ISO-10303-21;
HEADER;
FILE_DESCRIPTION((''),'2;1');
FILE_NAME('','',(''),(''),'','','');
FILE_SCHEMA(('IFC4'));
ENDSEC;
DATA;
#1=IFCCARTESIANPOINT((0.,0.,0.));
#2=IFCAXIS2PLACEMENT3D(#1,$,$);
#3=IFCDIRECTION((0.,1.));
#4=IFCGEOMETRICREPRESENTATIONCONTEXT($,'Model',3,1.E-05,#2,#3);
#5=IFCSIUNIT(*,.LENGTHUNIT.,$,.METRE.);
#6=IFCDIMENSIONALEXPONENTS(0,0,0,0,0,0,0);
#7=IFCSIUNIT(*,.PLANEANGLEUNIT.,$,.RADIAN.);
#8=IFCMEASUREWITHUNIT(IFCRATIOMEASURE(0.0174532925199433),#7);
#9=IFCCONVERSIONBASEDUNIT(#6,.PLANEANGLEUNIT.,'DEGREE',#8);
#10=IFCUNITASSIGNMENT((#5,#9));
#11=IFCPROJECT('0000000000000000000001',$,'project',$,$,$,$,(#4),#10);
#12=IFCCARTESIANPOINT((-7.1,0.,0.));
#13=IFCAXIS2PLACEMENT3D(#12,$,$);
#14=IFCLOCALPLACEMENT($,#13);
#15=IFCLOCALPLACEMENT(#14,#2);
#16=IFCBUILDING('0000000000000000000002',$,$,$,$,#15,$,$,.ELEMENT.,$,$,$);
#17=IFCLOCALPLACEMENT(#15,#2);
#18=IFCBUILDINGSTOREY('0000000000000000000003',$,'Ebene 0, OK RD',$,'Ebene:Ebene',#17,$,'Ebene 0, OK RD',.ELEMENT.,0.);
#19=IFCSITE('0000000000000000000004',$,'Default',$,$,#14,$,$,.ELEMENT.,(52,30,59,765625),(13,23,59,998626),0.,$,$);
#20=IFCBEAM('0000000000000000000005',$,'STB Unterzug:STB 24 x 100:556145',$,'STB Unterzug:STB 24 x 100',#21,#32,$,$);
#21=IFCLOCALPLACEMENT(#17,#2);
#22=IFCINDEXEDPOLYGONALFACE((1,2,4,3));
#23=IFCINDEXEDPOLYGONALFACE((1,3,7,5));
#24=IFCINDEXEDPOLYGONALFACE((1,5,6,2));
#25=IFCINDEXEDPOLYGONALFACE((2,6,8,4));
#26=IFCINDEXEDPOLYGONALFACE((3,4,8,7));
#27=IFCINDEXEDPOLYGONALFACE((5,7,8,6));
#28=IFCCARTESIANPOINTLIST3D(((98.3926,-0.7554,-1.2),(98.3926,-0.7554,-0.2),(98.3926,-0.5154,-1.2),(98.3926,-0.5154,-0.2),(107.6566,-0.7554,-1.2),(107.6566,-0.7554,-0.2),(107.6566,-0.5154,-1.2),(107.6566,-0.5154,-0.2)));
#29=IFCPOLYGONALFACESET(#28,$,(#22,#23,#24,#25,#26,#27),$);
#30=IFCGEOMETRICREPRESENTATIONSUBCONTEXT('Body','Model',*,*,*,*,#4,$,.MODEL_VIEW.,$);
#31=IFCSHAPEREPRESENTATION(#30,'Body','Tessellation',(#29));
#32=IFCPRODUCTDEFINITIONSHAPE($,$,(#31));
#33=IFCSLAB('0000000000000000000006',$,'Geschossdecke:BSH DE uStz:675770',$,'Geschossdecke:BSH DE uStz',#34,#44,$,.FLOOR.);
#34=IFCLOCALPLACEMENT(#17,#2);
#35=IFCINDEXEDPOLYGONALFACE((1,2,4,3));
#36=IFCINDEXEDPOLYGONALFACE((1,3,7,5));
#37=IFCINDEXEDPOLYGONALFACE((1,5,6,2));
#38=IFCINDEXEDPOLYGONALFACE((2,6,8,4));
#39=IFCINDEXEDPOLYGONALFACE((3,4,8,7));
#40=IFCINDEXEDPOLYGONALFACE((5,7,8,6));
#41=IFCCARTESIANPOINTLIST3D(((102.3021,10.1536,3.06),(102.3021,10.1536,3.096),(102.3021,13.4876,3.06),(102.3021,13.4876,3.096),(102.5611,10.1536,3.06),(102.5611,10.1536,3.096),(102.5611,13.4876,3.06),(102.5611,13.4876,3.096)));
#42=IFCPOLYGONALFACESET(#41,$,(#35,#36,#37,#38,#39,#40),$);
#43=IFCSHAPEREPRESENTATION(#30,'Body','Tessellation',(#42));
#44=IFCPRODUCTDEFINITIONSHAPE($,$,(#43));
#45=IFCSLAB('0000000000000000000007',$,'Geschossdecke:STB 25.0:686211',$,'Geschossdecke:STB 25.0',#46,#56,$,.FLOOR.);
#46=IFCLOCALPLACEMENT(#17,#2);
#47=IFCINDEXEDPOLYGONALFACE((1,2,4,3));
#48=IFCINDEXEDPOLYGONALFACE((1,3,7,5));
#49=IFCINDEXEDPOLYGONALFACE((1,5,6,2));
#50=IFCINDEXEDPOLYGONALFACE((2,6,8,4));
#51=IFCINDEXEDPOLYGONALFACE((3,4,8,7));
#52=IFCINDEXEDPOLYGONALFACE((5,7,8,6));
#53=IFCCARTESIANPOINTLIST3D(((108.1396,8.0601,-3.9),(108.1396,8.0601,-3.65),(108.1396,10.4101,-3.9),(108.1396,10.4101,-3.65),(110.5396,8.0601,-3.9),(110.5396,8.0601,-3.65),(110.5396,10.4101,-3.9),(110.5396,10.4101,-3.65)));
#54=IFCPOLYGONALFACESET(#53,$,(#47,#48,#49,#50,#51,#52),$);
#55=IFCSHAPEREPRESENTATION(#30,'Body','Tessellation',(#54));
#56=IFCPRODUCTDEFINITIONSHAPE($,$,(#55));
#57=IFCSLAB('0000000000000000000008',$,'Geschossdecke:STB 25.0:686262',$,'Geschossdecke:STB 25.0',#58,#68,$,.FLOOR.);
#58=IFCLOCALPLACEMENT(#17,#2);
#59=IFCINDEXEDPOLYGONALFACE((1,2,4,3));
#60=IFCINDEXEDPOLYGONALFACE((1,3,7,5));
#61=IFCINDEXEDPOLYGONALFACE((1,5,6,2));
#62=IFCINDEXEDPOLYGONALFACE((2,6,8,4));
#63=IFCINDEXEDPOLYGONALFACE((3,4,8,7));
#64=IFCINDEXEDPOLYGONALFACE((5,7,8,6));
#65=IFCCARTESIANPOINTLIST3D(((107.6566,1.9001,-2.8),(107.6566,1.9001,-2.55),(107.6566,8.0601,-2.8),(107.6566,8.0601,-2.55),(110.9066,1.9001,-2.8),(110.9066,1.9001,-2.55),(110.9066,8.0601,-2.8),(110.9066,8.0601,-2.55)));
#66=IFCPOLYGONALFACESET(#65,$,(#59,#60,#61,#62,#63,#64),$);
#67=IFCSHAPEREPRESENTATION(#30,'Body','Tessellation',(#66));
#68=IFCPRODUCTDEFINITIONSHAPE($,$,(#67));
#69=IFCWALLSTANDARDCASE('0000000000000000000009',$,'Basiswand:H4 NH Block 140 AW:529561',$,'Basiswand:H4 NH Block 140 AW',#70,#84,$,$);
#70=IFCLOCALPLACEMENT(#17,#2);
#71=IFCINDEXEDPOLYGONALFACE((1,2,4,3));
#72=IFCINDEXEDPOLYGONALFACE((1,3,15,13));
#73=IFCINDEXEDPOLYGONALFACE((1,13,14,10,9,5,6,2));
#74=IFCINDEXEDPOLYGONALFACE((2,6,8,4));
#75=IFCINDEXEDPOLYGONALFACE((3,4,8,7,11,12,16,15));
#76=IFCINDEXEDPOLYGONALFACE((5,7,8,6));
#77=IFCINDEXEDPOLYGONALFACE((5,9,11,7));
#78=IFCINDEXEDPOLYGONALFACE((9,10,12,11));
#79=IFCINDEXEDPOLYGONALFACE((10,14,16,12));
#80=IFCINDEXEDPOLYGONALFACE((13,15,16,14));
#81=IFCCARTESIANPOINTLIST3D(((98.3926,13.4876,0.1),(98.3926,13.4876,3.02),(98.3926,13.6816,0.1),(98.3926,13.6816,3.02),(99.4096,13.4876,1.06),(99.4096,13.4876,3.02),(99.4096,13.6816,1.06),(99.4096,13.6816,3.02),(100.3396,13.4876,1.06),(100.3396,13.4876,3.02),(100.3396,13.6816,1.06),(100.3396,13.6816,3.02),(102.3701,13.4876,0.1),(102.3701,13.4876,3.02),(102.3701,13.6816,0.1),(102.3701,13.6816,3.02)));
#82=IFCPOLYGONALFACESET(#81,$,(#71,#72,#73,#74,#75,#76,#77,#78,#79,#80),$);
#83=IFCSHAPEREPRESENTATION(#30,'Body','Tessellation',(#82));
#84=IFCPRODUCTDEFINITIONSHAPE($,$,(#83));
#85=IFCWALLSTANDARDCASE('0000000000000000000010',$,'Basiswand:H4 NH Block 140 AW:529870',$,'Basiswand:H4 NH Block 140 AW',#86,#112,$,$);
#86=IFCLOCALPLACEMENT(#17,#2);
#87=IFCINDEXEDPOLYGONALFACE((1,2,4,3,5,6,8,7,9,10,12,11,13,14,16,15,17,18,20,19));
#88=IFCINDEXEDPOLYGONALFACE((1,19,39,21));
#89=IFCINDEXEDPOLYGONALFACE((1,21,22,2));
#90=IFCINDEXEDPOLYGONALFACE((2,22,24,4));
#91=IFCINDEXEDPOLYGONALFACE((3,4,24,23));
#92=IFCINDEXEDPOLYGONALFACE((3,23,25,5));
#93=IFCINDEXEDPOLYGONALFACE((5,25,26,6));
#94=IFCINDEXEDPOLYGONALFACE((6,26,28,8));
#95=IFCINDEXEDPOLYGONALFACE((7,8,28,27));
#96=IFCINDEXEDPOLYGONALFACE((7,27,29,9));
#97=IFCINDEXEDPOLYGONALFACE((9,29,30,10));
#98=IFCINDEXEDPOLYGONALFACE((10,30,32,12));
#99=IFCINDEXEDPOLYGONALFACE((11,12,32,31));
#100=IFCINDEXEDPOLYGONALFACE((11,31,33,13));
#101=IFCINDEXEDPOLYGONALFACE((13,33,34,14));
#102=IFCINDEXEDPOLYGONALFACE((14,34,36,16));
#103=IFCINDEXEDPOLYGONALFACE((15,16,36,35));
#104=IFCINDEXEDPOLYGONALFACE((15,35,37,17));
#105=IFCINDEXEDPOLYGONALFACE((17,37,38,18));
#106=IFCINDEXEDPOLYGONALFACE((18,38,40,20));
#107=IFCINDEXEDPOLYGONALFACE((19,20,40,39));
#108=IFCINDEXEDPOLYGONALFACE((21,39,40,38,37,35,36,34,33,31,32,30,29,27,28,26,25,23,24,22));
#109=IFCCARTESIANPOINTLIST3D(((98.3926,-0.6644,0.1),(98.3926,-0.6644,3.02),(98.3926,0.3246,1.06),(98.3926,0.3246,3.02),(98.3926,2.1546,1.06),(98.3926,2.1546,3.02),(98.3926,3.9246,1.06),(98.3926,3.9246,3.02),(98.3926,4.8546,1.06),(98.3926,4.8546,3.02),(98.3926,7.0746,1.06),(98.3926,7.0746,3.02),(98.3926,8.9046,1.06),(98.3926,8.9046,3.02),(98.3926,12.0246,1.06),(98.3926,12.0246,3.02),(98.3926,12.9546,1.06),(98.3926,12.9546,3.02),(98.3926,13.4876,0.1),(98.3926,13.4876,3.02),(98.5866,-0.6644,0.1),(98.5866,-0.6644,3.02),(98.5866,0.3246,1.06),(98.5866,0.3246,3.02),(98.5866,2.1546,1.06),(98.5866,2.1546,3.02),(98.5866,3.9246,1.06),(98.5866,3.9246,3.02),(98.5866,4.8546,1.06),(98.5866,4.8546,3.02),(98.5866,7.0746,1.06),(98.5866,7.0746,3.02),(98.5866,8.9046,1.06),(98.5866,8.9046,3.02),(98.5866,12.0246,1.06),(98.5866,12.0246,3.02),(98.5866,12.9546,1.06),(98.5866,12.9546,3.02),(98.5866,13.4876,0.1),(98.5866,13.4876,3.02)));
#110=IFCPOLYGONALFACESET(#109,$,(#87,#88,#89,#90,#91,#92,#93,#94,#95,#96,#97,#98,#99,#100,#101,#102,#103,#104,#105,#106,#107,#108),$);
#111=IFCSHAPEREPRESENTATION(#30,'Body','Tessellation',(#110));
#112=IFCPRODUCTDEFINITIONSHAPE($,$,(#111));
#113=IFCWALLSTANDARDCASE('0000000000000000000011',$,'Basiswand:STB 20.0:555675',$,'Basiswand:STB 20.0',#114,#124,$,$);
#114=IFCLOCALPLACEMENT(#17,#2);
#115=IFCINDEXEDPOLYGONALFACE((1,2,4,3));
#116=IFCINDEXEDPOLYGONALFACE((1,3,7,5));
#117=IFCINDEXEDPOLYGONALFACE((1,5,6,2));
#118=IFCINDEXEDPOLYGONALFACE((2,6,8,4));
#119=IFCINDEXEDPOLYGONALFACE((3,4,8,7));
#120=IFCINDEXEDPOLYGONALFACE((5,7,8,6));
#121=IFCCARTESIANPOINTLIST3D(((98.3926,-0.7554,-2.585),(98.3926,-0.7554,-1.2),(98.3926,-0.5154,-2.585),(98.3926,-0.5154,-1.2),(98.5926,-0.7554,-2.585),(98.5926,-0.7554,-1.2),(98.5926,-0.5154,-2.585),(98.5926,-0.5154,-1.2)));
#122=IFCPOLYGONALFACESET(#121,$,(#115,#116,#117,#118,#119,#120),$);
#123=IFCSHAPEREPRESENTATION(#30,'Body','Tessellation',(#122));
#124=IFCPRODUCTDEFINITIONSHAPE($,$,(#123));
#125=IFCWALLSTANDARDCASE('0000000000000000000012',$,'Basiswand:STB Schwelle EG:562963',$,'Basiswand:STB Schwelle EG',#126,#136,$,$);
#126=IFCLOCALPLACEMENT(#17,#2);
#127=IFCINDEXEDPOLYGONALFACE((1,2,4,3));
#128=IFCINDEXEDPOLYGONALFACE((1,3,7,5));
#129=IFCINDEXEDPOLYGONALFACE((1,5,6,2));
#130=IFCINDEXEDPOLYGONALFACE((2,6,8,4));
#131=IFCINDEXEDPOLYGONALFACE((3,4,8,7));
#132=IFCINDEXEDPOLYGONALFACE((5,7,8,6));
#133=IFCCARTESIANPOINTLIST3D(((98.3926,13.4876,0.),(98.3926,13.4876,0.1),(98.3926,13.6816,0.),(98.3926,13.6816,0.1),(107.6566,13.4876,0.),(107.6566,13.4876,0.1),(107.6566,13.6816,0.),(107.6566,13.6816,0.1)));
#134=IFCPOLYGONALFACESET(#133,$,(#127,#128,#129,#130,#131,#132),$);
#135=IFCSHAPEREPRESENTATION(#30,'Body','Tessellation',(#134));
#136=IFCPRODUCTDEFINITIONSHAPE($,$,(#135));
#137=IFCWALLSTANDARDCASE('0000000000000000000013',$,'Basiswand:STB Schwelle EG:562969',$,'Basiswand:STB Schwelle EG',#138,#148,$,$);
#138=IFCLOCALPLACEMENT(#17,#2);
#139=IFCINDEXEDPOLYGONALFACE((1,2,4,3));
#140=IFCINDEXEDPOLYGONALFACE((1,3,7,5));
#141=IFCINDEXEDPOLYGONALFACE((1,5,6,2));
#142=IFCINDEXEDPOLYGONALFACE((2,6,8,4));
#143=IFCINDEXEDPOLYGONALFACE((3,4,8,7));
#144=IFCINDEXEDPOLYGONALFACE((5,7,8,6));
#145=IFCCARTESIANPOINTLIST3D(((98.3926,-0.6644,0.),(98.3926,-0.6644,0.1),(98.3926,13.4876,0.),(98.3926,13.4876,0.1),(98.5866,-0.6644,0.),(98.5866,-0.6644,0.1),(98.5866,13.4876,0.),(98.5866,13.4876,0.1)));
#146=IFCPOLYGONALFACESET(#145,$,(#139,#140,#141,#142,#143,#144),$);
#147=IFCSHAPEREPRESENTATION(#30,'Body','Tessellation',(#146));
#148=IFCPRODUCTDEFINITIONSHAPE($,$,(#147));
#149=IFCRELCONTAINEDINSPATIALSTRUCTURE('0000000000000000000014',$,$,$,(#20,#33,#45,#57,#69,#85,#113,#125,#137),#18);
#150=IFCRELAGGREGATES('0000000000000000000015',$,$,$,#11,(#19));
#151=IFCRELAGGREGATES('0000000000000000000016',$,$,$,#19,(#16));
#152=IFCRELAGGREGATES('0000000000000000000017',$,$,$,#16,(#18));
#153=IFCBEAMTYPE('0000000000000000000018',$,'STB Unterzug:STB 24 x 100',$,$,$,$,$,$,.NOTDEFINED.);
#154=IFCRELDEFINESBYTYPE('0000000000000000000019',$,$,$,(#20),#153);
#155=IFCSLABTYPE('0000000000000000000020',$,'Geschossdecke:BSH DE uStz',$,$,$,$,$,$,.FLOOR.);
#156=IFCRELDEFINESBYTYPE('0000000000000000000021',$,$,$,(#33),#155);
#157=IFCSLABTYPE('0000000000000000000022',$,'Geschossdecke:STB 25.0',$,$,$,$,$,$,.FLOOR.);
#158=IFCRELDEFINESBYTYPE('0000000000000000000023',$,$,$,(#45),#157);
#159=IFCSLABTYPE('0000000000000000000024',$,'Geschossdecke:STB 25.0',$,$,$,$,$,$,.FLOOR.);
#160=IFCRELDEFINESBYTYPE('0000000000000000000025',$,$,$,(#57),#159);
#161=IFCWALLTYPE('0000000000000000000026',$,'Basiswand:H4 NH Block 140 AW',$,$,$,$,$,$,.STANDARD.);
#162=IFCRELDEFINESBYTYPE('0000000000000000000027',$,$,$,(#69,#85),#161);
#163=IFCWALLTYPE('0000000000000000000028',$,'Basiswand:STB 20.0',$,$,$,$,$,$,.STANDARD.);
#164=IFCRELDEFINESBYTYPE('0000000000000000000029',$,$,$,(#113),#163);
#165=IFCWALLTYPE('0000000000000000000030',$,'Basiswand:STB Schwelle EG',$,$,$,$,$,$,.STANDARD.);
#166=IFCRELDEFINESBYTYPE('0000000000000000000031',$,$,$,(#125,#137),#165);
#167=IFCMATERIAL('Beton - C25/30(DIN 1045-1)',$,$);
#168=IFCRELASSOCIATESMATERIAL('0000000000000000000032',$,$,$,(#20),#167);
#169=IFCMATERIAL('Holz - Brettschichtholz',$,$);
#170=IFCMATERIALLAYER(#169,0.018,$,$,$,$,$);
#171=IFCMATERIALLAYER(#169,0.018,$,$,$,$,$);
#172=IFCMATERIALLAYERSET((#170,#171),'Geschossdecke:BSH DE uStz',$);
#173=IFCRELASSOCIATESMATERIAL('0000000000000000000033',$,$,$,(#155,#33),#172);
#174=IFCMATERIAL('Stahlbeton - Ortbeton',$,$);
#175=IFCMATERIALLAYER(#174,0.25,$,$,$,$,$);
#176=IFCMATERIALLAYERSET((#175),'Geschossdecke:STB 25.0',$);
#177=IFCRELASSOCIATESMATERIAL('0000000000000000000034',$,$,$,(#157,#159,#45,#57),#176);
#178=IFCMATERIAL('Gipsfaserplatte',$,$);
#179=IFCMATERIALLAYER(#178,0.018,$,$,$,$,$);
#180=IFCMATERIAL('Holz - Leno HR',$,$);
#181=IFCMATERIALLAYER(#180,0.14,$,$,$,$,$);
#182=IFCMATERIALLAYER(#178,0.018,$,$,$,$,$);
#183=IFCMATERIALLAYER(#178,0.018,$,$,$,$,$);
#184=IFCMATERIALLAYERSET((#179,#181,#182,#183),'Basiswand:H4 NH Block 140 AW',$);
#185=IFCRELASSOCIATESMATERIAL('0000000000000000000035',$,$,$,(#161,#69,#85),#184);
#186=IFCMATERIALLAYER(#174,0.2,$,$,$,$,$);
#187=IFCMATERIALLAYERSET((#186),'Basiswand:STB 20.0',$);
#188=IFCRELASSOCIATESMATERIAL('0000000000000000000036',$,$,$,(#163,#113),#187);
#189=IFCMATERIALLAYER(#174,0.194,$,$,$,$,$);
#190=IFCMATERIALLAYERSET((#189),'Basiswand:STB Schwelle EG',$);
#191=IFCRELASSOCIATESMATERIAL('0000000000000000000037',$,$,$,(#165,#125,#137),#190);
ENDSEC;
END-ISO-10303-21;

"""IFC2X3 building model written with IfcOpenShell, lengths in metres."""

from ifc_helpers import new_model, entity, si_unit, converted_unit, direction, frame, frame_2d, origin, origin_2d_with_axis, place, context, subcontext, project, spatial, rectangle, extrude, material, layer, layer_set, layer_usage, type_object, element, save


model = new_model("IFC2X3")

# Units and contexts
model_context = context("Model", 3, precision=1e-05, world=origin(), true_north=direction((0.0, 1.0)))
body_context = subcontext(model_context, "Body", "Model", "MODEL_VIEW")
ifc_project = project(units=[si_unit("LENGTHUNIT", "METRE"), converted_unit("PLANEANGLEUNIT", "DEGREE", entity("IfcRatioMeasure", 0.0174532925199433), si_unit("PLANEANGLEUNIT", "RADIAN"), dimensions=[0, 0, 0, 0, 0, 0, 0])], contexts=[model_context])

# Site, building, storey
site_placement = place(None, frame((-7.1, 0.0, 0.0)))
site = spatial("IfcSite", under=ifc_project, at=site_placement, Name="Default", CompositionType="ELEMENT", RefLatitude=(52, 30, 59, 765625), RefLongitude=(13, 23, 59, 998626), RefElevation=0.0)
building_placement = place(site_placement, origin())
building = spatial("IfcBuilding", under=site, at=building_placement, CompositionType="ELEMENT")
storey_placement = place(building_placement, origin())
storey = spatial("IfcBuildingStorey", under=building, at=storey_placement, Name="Ebene 0, OK RD", ObjectType="Ebene:Ebene", LongName="Ebene 0, OK RD", CompositionType="ELEMENT", Elevation=0.0)

# Beam
ifc_material_1 = material(Name="Beton - C25/30(DIN 1045-1)")
beam_type = type_object("IfcBeamType", Name="STB Unterzug:STB 24 x 100", PredefinedType="NOTDEFINED")
beam_placement = place(storey_placement, frame((98.3926, -0.6354, -0.2)))
element("IfcBeam", 1, at=beam_placement, inside=storey, type_object=beam_type, material=ifc_material_1, Name="STB Unterzug:STB 24 x 100:556145", ObjectType="STB Unterzug:STB 24 x 100", context=body_context, shape_type="SweptSolid", body=[
    extrude(rectangle(XDim=1.0, YDim=0.24, at=frame_2d((0.0, 0.0), x_axis=(1.0, 0.0))), frame((0.0, 0.0, -0.5), z_axis=(1.0, 0.0, 0.0), x_axis=(0.0, 0.0, -1.0)), (0.0, 0.0, 1.0), 9.264),
])

# Slabs
ifc_material_2 = material(Name="Holz - Brettschichtholz")
ifc_layer_1 = layer(ifc_material_2, 0.018)
ifc_layer_2 = layer(ifc_material_2, 0.018)
ifc_layer_set_1 = layer_set([ifc_layer_1, ifc_layer_2], Name="Geschossdecke:BSH DE uStz")
ifc_layer_usage_1 = layer_usage(ifc_layer_set_1, "AXIS3", "POSITIVE", 0.0)
slab_type_1 = type_object("IfcSlabType", Name="Geschossdecke:BSH DE uStz", PredefinedType="FLOOR", material=ifc_layer_set_1)
slab_1_placement = place(storey_placement, origin())
element("IfcSlab", 2, at=slab_1_placement, inside=storey, type_object=slab_type_1, material=ifc_layer_usage_1, Name="Geschossdecke:BSH DE uStz:675770", ObjectType="Geschossdecke:BSH DE uStz", PredefinedType="FLOOR", context=body_context, shape_type="SweptSolid", body=[
    extrude(rectangle(XDim=3.334, YDim=0.259, at=origin_2d_with_axis()), frame((102.4316, 11.8206, 3.096), z_axis=(0.0, 0.0, -1.0), x_axis=(0.0, 1.0, 0.0)), (0.0, 0.0, 1.0), 0.036),
])
ifc_material_3 = material(Name="Stahlbeton - Ortbeton")
ifc_layer_3 = layer(ifc_material_3, 0.25)
ifc_layer_set_2 = layer_set([ifc_layer_3], Name="Geschossdecke:STB 25.0")
ifc_layer_usage_2 = layer_usage(ifc_layer_set_2, "AXIS3", "POSITIVE", 0.0)
slab_type_2 = type_object("IfcSlabType", Name="Geschossdecke:STB 25.0", PredefinedType="FLOOR", material=ifc_layer_set_2)
slab_2_placement = place(storey_placement, origin())
element("IfcSlab", 3, at=slab_2_placement, inside=storey, type_object=slab_type_2, material=ifc_layer_usage_2, Name="Geschossdecke:STB 25.0:686211", ObjectType="Geschossdecke:STB 25.0", PredefinedType="FLOOR", context=body_context, shape_type="SweptSolid", body=[
    extrude(rectangle(XDim=2.35, YDim=2.4, at=frame_2d((0.0, 0.0), x_axis=(1.0, 0.0))), frame((109.3396, 9.2351, -3.65), z_axis=(0.0, 0.0, -1.0), x_axis=(0.0, 1.0, 0.0)), (0.0, 0.0, 1.0), 0.25),
])
ifc_layer_usage_3 = layer_usage(ifc_layer_set_2, "AXIS3", "POSITIVE", 0.0)
slab_type_3 = type_object("IfcSlabType", Name="Geschossdecke:STB 25.0", PredefinedType="FLOOR", material=ifc_layer_set_2)
slab_3_placement = place(storey_placement, origin())
element("IfcSlab", 4, at=slab_3_placement, inside=storey, type_object=slab_type_3, material=ifc_layer_usage_3, Name="Geschossdecke:STB 25.0:686262", ObjectType="Geschossdecke:STB 25.0", PredefinedType="FLOOR", context=body_context, shape_type="SweptSolid", body=[
    extrude(rectangle(XDim=6.16, YDim=3.25, at=frame_2d((0.0, 0.0), x_axis=(1.0, 0.0))), frame((109.2816, 4.9801, -2.55), z_axis=(0.0, 0.0, -1.0), x_axis=(0.0, 1.0, 0.0)), (0.0, 0.0, 1.0), 0.25),
])

# Wall, opening
ifc_material_4 = material(Name="Gipsfaserplatte")
ifc_layer_4 = layer(ifc_material_4, 0.018)
ifc_material_5 = material(Name="Holz - Leno HR")
ifc_layer_5 = layer(ifc_material_5, 0.14)
ifc_layer_6 = layer(ifc_material_4, 0.018)
ifc_layer_7 = layer(ifc_material_4, 0.018)
ifc_layer_set_3 = layer_set([ifc_layer_4, ifc_layer_5, ifc_layer_6, ifc_layer_7], Name="Basiswand:H4 NH Block 140 AW")
ifc_layer_usage_4 = layer_usage(ifc_layer_set_3, "AXIS2", "NEGATIVE", 0.097)
wall_type_1 = type_object("IfcWallType", Name="Basiswand:H4 NH Block 140 AW", PredefinedType="STANDARD", material=ifc_layer_set_3)
wall_1_placement = place(storey_placement, frame((98.3926, 13.5846, 0.1)))
wall_1 = element("IfcWallStandardCase", 5, at=wall_1_placement, inside=storey, type_object=wall_type_1, material=ifc_layer_usage_4, Name="Basiswand:H4 NH Block 140 AW:529561", ObjectType="Basiswand:H4 NH Block 140 AW", context=body_context, shape_type="SweptSolid", body=[
    extrude(rectangle(XDim=3.9775, YDim=0.194, at=frame_2d((1.9888, 0.0), x_axis=(-1.0, 0.0))), origin(), (0.0, 0.0, 1.0), 2.92),
])
opening_1_placement = place(wall_1_placement, origin())
element("IfcOpeningElement", 6, at=opening_1_placement, cuts=wall_1, ObjectType="Opening", context=body_context, shape_type="SweptSolid", body=[
    extrude(rectangle(XDim=2.0, YDim=0.93, at=frame_2d((0.0, 0.0), x_axis=(1.0, 0.0))), frame((1.482, -0.097, 1.96), z_axis=(0.0, 1.0, 0.0), x_axis=(0.0, 0.0, -1.0)), (0.0, 0.0, 1.0), 0.194),
])

# Wall, openings
ifc_layer_usage_5 = layer_usage(ifc_layer_set_3, "AXIS2", "NEGATIVE", 0.097)
wall_2_placement = place(storey_placement, frame((98.4896, -0.6644, 0.1), z_axis=(0.0, 0.0, 1.0), x_axis=(0.0, 1.0, 0.0)))
wall_2 = element("IfcWallStandardCase", 7, at=wall_2_placement, inside=storey, type_object=wall_type_1, material=ifc_layer_usage_5, Name="Basiswand:H4 NH Block 140 AW:529870", ObjectType="Basiswand:H4 NH Block 140 AW", context=body_context, shape_type="SweptSolid", body=[
    extrude(rectangle(XDim=14.152, YDim=0.194, at=frame_2d((7.076, 0.0), x_axis=(-1.0, 0.0))), origin(), (0.0, 0.0, 1.0), 2.92),
])
opening_2_placement = place(wall_2_placement, origin())
element("IfcOpeningElement", 8, at=opening_2_placement, cuts=wall_2, ObjectType="Opening", context=body_context, shape_type="SweptSolid", body=[
    extrude(rectangle(XDim=2.0, YDim=0.93, at=origin_2d_with_axis()), frame((13.154, -0.097, 1.96), z_axis=(0.0, 1.0, 0.0), x_axis=(0.0, 0.0, -1.0)), (0.0, 0.0, 1.0), 0.194),
])
opening_3_placement = place(wall_2_placement, origin())
element("IfcOpeningElement", 9, at=opening_3_placement, cuts=wall_2, ObjectType="Opening", context=body_context, shape_type="SweptSolid", body=[
    extrude(rectangle(XDim=2.0, YDim=1.83, at=origin_2d_with_axis()), frame((8.654, -0.097, 1.96), z_axis=(0.0, 1.0, 0.0), x_axis=(0.0, 0.0, -1.0)), (0.0, 0.0, 1.0), 0.194),
])
opening_4_placement = place(wall_2_placement, origin())
element("IfcOpeningElement", 10, at=opening_4_placement, cuts=wall_2, ObjectType="Opening", context=body_context, shape_type="SweptSolid", body=[
    extrude(rectangle(XDim=2.0, YDim=0.93, at=frame_2d((0.0, 0.0), x_axis=(1.0, 0.0))), frame((5.054, -0.097, 1.96), z_axis=(0.0, 1.0, 0.0), x_axis=(0.0, 0.0, -1.0)), (0.0, 0.0, 1.0), 0.194),
])
opening_5_placement = place(wall_2_placement, origin())
element("IfcOpeningElement", 11, at=opening_5_placement, cuts=wall_2, ObjectType="Opening", context=body_context, shape_type="SweptSolid", body=[
    extrude(rectangle(XDim=2.0, YDim=1.83, at=frame_2d((0.0, 0.0), x_axis=(1.0, 0.0))), frame((1.904, -0.097, 1.96), z_axis=(0.0, 1.0, 0.0), x_axis=(0.0, 0.0, -1.0)), (0.0, 0.0, 1.0), 0.194),
])

# Walls
ifc_layer_8 = layer(ifc_material_3, 0.2)
ifc_layer_set_4 = layer_set([ifc_layer_8], Name="Basiswand:STB 20.0")
ifc_layer_usage_6 = layer_usage(ifc_layer_set_4, "AXIS2", "NEGATIVE", 0.1)
wall_type_2 = type_object("IfcWallType", Name="Basiswand:STB 20.0", PredefinedType="STANDARD", material=ifc_layer_set_4)
wall_3_placement = place(storey_placement, frame((98.4926, -0.7554, -2.585), z_axis=(0.0, 0.0, 1.0), x_axis=(0.0, 1.0, 0.0)))
element("IfcWallStandardCase", 12, at=wall_3_placement, inside=storey, type_object=wall_type_2, material=ifc_layer_usage_6, Name="Basiswand:STB 20.0:555675", ObjectType="Basiswand:STB 20.0", context=body_context, shape_type="SweptSolid", body=[
    extrude(rectangle(XDim=0.24, YDim=0.2, at=frame_2d((0.12, 0.0), x_axis=(-1.0, 0.0))), origin(), (0.0, 0.0, 1.0), 1.385),
])
ifc_layer_9 = layer(ifc_material_3, 0.194)
ifc_layer_set_5 = layer_set([ifc_layer_9], Name="Basiswand:STB Schwelle EG")
ifc_layer_usage_7 = layer_usage(ifc_layer_set_5, "AXIS2", "NEGATIVE", 0.097)
wall_type_3 = type_object("IfcWallType", Name="Basiswand:STB Schwelle EG", PredefinedType="STANDARD", material=ifc_layer_set_5)
wall_4_placement = place(storey_placement, frame((98.3926, 13.5846, 0.0)))
element("IfcWallStandardCase", 13, at=wall_4_placement, inside=storey, type_object=wall_type_3, material=ifc_layer_usage_7, Name="Basiswand:STB Schwelle EG:562963", ObjectType="Basiswand:STB Schwelle EG", context=body_context, shape_type="SweptSolid", body=[
    extrude(rectangle(XDim=9.264, YDim=0.194, at=frame_2d((4.632, 0.0), x_axis=(-1.0, 0.0))), origin(), (0.0, 0.0, 1.0), 0.1),
])
ifc_layer_usage_8 = layer_usage(ifc_layer_set_5, "AXIS2", "NEGATIVE", 0.097)
wall_5_placement = place(storey_placement, frame((98.4896, -0.6644, 0.0), z_axis=(0.0, 0.0, 1.0), x_axis=(0.0, 1.0, 0.0)))
element("IfcWallStandardCase", 14, at=wall_5_placement, inside=storey, type_object=wall_type_3, material=ifc_layer_usage_8, Name="Basiswand:STB Schwelle EG:562969", ObjectType="Basiswand:STB Schwelle EG", context=body_context, shape_type="SweptSolid", body=[
    extrude(rectangle(XDim=14.152, YDim=0.194, at=frame_2d((7.076, 0.0), x_axis=(-1.0, 0.0))), origin(), (0.0, 0.0, 1.0), 0.1),
])

save(model, "model.ifc")
